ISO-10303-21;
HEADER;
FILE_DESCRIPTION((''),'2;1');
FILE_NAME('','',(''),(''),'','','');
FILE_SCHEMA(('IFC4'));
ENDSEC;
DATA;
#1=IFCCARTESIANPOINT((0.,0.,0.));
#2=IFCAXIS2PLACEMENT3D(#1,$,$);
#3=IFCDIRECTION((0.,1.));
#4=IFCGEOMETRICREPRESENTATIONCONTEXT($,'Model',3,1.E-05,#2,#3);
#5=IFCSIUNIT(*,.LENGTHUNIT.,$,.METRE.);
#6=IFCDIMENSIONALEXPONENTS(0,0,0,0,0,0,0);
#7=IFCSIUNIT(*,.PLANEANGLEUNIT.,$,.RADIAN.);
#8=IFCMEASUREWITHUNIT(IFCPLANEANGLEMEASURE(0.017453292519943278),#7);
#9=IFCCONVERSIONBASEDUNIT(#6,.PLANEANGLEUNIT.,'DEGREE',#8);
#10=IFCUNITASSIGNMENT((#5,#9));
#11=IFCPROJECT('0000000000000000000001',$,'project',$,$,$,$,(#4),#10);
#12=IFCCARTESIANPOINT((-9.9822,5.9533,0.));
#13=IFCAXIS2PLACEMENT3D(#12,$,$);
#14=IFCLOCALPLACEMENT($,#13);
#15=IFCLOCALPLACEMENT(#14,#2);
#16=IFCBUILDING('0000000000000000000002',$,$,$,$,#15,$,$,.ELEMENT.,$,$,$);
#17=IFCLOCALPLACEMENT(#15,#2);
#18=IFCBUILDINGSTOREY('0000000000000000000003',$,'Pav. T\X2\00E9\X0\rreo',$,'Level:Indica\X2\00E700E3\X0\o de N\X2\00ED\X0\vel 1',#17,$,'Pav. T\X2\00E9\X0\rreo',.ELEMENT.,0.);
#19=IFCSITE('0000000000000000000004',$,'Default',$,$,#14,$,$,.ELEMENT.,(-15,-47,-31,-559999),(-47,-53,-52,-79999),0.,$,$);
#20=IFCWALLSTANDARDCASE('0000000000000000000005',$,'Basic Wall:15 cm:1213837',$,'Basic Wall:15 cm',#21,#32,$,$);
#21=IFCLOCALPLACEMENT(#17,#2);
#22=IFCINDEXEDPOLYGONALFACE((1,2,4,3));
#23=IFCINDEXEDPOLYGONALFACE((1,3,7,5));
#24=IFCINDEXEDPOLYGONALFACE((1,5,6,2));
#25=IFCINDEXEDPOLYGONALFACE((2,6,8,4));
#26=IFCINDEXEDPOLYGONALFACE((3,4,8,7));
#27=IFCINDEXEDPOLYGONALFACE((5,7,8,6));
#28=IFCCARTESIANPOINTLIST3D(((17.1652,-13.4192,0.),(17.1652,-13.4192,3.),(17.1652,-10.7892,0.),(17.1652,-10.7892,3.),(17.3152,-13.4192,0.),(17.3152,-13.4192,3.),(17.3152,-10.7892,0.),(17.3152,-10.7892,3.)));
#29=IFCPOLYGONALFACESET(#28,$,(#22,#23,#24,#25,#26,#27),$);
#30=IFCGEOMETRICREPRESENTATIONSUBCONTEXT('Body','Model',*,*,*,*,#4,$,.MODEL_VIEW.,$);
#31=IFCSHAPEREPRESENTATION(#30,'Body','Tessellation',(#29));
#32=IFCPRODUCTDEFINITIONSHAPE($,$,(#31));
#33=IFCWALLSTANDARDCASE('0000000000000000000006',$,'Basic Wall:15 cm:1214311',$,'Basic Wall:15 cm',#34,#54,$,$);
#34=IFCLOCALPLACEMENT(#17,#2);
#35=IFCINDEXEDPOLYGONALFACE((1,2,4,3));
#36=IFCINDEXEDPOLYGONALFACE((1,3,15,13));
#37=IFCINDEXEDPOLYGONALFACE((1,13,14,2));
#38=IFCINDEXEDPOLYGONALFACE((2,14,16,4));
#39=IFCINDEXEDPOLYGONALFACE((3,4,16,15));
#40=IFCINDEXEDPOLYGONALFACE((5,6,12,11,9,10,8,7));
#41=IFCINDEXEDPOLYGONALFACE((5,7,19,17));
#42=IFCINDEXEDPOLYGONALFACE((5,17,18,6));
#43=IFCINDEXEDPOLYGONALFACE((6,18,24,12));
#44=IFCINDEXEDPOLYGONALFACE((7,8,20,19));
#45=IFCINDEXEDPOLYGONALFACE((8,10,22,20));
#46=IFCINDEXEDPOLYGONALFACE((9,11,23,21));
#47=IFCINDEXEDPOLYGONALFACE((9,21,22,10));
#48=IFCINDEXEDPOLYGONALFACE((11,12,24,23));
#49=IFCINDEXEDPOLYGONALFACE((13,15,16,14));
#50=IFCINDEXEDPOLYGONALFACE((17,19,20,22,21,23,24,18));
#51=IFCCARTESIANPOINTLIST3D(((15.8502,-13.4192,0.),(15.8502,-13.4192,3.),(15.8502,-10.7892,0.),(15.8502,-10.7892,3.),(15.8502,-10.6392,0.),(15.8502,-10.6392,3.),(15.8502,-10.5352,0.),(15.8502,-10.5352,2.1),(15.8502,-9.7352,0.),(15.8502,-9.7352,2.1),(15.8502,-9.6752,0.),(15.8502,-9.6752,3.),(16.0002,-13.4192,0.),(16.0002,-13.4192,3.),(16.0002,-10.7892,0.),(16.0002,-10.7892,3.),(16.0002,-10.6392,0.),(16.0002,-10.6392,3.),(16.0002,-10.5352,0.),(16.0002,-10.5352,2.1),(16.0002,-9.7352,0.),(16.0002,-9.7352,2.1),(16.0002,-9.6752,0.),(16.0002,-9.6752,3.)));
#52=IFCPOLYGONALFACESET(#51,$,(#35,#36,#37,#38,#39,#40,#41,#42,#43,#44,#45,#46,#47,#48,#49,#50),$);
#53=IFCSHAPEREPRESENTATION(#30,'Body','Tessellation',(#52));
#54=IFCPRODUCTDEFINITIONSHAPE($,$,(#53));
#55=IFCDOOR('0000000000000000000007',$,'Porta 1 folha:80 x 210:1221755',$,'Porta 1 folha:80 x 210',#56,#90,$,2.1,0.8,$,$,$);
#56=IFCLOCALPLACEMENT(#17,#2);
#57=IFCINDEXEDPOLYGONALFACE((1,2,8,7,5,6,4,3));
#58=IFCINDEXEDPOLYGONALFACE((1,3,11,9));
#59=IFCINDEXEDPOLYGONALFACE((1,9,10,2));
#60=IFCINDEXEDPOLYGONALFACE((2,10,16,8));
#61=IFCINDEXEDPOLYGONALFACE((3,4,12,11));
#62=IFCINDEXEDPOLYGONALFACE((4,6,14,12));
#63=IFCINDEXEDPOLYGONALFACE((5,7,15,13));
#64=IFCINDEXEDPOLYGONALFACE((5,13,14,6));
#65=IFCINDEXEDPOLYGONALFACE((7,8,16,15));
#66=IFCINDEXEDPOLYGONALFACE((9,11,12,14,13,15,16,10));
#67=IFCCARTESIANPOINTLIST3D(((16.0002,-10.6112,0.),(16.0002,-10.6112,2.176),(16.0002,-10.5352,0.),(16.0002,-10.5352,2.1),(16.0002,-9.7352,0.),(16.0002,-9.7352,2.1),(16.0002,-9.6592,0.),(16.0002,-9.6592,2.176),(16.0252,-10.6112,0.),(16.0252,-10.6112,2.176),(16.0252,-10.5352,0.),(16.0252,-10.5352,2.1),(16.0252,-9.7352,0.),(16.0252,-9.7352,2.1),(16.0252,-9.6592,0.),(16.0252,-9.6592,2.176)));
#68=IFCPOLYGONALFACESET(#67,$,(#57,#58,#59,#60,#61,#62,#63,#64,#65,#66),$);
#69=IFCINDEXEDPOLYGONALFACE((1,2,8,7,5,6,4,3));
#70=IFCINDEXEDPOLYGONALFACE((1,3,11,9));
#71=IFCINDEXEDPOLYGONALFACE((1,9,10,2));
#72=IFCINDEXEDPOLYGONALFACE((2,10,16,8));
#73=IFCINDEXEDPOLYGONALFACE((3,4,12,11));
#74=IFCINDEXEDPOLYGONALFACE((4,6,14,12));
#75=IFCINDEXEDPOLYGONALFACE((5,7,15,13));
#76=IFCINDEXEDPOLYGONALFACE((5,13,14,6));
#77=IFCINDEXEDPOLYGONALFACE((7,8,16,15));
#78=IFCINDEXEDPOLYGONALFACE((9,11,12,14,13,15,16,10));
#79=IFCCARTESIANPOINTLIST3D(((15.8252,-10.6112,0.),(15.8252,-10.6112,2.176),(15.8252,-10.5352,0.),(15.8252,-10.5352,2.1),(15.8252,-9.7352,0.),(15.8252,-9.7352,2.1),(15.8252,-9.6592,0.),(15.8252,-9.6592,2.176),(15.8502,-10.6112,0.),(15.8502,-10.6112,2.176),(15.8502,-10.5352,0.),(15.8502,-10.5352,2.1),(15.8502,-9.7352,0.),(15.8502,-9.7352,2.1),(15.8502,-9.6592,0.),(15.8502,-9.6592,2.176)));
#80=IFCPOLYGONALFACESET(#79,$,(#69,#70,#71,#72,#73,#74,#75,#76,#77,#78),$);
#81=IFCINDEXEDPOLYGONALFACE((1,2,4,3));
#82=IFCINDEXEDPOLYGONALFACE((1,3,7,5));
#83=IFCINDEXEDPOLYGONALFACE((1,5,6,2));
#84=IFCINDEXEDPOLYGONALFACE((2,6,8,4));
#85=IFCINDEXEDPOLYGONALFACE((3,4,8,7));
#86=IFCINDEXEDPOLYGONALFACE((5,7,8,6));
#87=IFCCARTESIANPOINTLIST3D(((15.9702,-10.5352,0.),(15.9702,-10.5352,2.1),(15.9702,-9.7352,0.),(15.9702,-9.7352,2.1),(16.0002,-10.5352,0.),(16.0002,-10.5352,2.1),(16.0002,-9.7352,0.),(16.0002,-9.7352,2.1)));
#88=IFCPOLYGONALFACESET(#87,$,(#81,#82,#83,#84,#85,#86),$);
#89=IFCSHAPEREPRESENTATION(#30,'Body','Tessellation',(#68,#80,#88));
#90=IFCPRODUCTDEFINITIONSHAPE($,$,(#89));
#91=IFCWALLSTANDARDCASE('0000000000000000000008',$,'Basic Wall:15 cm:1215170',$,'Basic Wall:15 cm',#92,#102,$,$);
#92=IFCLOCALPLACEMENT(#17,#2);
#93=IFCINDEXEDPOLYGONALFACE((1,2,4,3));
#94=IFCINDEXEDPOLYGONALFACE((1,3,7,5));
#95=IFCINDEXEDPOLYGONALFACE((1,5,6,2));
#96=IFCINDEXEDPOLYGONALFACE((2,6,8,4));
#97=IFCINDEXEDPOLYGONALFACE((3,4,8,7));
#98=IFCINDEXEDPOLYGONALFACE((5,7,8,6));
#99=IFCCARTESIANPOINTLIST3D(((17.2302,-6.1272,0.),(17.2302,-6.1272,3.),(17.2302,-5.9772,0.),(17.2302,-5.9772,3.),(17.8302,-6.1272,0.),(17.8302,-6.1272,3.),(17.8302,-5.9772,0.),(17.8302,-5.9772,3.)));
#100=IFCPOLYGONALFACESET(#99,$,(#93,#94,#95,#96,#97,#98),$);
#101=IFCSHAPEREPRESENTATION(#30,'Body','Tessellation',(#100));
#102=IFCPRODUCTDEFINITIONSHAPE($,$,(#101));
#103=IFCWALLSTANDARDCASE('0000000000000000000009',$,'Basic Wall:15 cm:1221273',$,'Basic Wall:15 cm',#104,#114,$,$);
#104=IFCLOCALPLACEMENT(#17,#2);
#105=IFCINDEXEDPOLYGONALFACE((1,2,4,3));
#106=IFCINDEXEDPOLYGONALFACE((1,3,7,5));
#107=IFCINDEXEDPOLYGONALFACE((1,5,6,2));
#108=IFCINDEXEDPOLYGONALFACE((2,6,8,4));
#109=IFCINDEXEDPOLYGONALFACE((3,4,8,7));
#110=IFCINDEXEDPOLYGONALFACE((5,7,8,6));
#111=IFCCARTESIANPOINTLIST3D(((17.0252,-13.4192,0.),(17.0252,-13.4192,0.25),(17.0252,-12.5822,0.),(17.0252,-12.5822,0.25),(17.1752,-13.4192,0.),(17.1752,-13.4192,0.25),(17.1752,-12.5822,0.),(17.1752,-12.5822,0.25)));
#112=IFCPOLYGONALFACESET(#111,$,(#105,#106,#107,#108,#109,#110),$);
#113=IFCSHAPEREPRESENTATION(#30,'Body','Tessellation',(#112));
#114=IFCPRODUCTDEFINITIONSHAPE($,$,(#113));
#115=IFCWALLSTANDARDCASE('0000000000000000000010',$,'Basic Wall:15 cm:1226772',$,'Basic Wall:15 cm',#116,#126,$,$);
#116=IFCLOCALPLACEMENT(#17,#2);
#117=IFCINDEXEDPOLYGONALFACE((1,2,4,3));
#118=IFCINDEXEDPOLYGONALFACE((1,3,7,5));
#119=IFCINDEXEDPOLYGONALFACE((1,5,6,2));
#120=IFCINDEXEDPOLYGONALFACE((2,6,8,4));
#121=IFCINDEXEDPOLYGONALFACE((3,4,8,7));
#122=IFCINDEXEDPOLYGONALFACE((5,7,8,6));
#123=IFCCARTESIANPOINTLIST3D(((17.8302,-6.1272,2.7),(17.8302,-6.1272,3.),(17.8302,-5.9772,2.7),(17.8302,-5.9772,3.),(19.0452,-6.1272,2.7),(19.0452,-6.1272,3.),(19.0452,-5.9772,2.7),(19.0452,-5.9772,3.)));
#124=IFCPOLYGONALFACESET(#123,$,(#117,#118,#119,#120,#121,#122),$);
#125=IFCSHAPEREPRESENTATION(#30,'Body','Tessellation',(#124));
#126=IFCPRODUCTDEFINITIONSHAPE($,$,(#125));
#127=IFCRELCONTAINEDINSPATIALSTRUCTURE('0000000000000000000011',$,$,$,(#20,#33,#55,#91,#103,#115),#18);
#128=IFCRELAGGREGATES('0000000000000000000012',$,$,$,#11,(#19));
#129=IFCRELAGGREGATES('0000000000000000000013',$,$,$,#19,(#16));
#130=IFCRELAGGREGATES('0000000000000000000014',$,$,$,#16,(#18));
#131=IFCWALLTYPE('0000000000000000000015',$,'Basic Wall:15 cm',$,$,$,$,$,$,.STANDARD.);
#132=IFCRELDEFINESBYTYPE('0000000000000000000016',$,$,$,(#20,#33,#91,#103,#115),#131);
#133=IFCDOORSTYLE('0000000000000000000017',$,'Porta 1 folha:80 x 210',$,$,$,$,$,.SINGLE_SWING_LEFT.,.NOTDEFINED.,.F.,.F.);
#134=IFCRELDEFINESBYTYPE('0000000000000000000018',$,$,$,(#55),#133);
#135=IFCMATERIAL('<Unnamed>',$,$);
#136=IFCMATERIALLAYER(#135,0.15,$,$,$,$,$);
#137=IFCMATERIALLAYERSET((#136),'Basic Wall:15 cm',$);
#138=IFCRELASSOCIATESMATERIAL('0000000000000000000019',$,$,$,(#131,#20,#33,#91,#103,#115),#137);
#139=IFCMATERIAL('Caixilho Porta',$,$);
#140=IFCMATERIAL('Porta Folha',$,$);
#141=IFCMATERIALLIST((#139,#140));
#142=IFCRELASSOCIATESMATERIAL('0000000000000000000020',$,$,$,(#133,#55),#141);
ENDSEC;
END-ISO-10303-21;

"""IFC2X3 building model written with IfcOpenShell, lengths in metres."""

from ifc_helpers import new_model, entity, si_unit, converted_unit, direction, frame, frame_2d, origin, origin_2d_with_axis, place, context, subcontext, project, spatial, polyline, rectangle, outline, extrude, source, transform, mapped, material, material_list, layer, layer_set, layer_usage, type_object, type_shapes, element, fill, save


model = new_model("IFC2X3")

# Units and contexts
model_context = context("Model", 3, precision=1e-05, world=origin(), true_north=direction((0.0, 1.0)))
body_context = subcontext(model_context, "Body", "Model", "MODEL_VIEW")
ifc_project = project(units=[si_unit("LENGTHUNIT", "METRE"), converted_unit("PLANEANGLEUNIT", "DEGREE", entity("IfcPlaneAngleMeasure", 0.017453292519943278), si_unit("PLANEANGLEUNIT", "RADIAN"), dimensions=[0, 0, 0, 0, 0, 0, 0])], contexts=[model_context])

# Site, building, storey
site_placement = place(None, frame((-9.9822, 5.9533, 0.0)))
site = spatial("IfcSite", under=ifc_project, at=site_placement, Name="Default", CompositionType="ELEMENT", RefLatitude=(-15, -47, -31, -559999), RefLongitude=(-47, -53, -52, -79999), RefElevation=0.0)
building_placement = place(site_placement, origin())
building = spatial("IfcBuilding", under=site, at=building_placement, CompositionType="ELEMENT")
storey_placement = place(building_placement, origin())
storey = spatial("IfcBuildingStorey", under=building, at=storey_placement, Name="Pav. Térreo", ObjectType="Level:Indicação de Nível 1", LongName="Pav. Térreo", CompositionType="ELEMENT", Elevation=0.0)

# Shared definitions
ifc_material_1 = material(Name="<Unnamed>")

# Shared definitions
ifc_layer = layer(ifc_material_1, 0.15)
ifc_layer_set = layer_set([ifc_layer], Name="Basic Wall:15 cm")
wall_type = type_object("IfcWallType", Name="Basic Wall:15 cm", PredefinedType="STANDARD", material=ifc_layer_set)

# Wall
ifc_layer_usage_1 = layer_usage(ifc_layer_set, "AXIS2", "NEGATIVE", 0.075)
wall_1_placement = place(storey_placement, frame((17.2402, -10.7892, 0.0), z_axis=(0.0, 0.0, 1.0), x_axis=(0.0, -1.0, 0.0)))
element("IfcWallStandardCase", 1, at=wall_1_placement, inside=storey, type_object=wall_type, material=ifc_layer_usage_1, Name="Basic Wall:15 cm:1213837", ObjectType="Basic Wall:15 cm", context=body_context, shape_type="SweptSolid", body=[
    extrude(rectangle(XDim=2.63, YDim=0.15, at=frame_2d((1.315, 0.0), x_axis=(-1.0, 0.0))), origin(), (0.0, 0.0, 1.0), 3.0),
])

# Wall, openings, door
ifc_layer_usage_2 = layer_usage(ifc_layer_set, "AXIS2", "NEGATIVE", 0.075)
wall_2_placement = place(storey_placement, frame((15.9252, -9.6752, 0.0), z_axis=(0.0, 0.0, 1.0), x_axis=(0.0, -1.0, 0.0)))
wall_2 = element("IfcWallStandardCase", 2, at=wall_2_placement, inside=storey, type_object=wall_type, material=ifc_layer_usage_2, Name="Basic Wall:15 cm:1214311", ObjectType="Basic Wall:15 cm", context=body_context, shape_type="SweptSolid", body=[
    extrude(rectangle(XDim=3.744, YDim=0.15, at=frame_2d((1.872, 0.0), x_axis=(-1.0, 0.0))), origin(), (0.0, 0.0, 1.0), 3.0),
])
opening_1_placement = place(storey_placement, frame((15.9252, -9.6752, 0.0), z_axis=(0.0, 0.0, 1.0), x_axis=(0.0, -1.0, 0.0)))
element("IfcOpeningElement", 3, at=opening_1_placement, cuts=wall_2, ObjectType="Opening", context=body_context, shape_type="SweptSolid", body=[
    extrude(rectangle(XDim=3.0, YDim=0.15, at=origin_2d_with_axis()), frame((1.114, 0.0, 1.5), z_axis=(-1.0, 0.0, 0.0), x_axis=(0.0, 0.0, 1.0)), (0.0, 0.0, 1.0), 0.15),
])
opening_2_placement = place(wall_2_placement, frame((0.06, -0.075, 0.0)))
opening_2 = element("IfcOpeningElement", 4, at=opening_2_placement, cuts=wall_2, ObjectType="Opening", context=body_context, shape_type="SweptSolid", body=[
    extrude(rectangle(XDim=0.8, YDim=2.1, at=frame_2d((1.05, 0.4), x_axis=(0.0, -1.0))), frame((0.0, 0.0, 0.0), z_axis=(0.0, 1.0, 0.0), x_axis=(0.0, 0.0, 1.0)), (0.0, 0.0, 1.0), 0.15),
])
ifc_material_2 = material(Name="Caixilho Porta")
ifc_material_3 = material(Name="Porta Folha")
ifc_material_list_1 = material_list([ifc_material_2, ifc_material_3])
door_style = type_object("IfcDoorStyle", Name="Porta 1 folha:80 x 210", ConstructionType="NOTDEFINED", OperationType="SINGLE_SWING_LEFT", ParameterTakesPrecedence=False, Sizeable=False, material=ifc_material_list_1)
shared_shape_1 = source(origin(), body_context, "Body", "SweptSolid", [
    extrude(outline(polyline([(-0.476, -1.107), (0.476, -1.107), (0.476, 1.069), (0.4, 1.069), (0.4, -1.031), (-0.4, -1.031), (-0.4, 1.069), (-0.476, 1.069), (-0.476, -1.107)])), frame((0.4, 0.175, 1.069), z_axis=(0.0, -1.0, 0.0), x_axis=(-1.0, 0.0, 0.0)), (0.0, 0.0, 1.0), 0.025),
    extrude(outline(polyline([(-1.107, -0.476), (1.069, -0.476), (1.069, -0.4), (-1.031, -0.4), (-1.031, 0.4), (1.069, 0.4), (1.069, 0.476), (-1.107, 0.476), (-1.107, -0.476)])), frame((0.4, 0.0, 1.069), z_axis=(0.0, -1.0, 0.0), x_axis=(0.0, 0.0, -1.0)), (0.0, 0.0, 1.0), 0.025),
    extrude(rectangle(XDim=0.8, YDim=0.03, at=origin_2d_with_axis()), frame((0.4, 0.135, 0.0)), (0.0, 0.0, 1.0), 2.1),
])
type_shapes(door_style, [shared_shape_1])
door_placement = place(opening_2_placement, origin())
door = element("IfcDoor", 5, at=door_placement, inside=storey, type_object=door_style, material=ifc_material_list_1, Name="Porta 1 folha:80 x 210:1221755", ObjectType="Porta 1 folha:80 x 210", OverallHeight=2.1, OverallWidth=0.8, context=body_context, shape_type="MappedRepresentation", body=[
    mapped(shared_shape_1, transform((0.0, 0.0, 0.0), scale=1.0)),
])
fill(opening_2, door)

# Walls
ifc_layer_usage_3 = layer_usage(ifc_layer_set, "AXIS2", "NEGATIVE", 0.075)
wall_3_placement = place(storey_placement, frame((17.2302, -6.0522, 0.0)))
element("IfcWallStandardCase", 6, at=wall_3_placement, inside=storey, type_object=wall_type, material=ifc_layer_usage_3, Name="Basic Wall:15 cm:1215170", ObjectType="Basic Wall:15 cm", context=body_context, shape_type="SweptSolid", body=[
    extrude(rectangle(XDim=0.6, YDim=0.15, at=frame_2d((0.3, 0.0), x_axis=(-1.0, 0.0))), origin(), (0.0, 0.0, 1.0), 3.0),
])
ifc_layer_usage_4 = layer_usage(ifc_layer_set, "AXIS2", "NEGATIVE", 0.075)
wall_4_placement = place(storey_placement, frame((17.1002, -12.5822, 0.0), z_axis=(0.0, 0.0, 1.0), x_axis=(0.0, -1.0, 0.0)))
element("IfcWallStandardCase", 7, at=wall_4_placement, inside=storey, type_object=wall_type, material=ifc_layer_usage_4, Name="Basic Wall:15 cm:1221273", ObjectType="Basic Wall:15 cm", context=body_context, shape_type="SweptSolid", body=[
    extrude(rectangle(XDim=0.837, YDim=0.15, at=frame_2d((0.4185, 0.0), x_axis=(-1.0, 0.0))), origin(), (0.0, 0.0, 1.0), 0.25),
])
ifc_layer_usage_5 = layer_usage(ifc_layer_set, "AXIS2", "NEGATIVE", 0.075)
wall_5_placement = place(storey_placement, frame((17.8302, -6.0522, 2.7)))
element("IfcWallStandardCase", 8, at=wall_5_placement, inside=storey, type_object=wall_type, material=ifc_layer_usage_5, Name="Basic Wall:15 cm:1226772", ObjectType="Basic Wall:15 cm", context=body_context, shape_type="SweptSolid", body=[
    extrude(rectangle(XDim=1.215, YDim=0.15, at=frame_2d((0.6075, 0.0), x_axis=(-1.0, 0.0))), origin(), (0.0, 0.0, 1.0), 0.3),
])

save(model, "model.ifc")
